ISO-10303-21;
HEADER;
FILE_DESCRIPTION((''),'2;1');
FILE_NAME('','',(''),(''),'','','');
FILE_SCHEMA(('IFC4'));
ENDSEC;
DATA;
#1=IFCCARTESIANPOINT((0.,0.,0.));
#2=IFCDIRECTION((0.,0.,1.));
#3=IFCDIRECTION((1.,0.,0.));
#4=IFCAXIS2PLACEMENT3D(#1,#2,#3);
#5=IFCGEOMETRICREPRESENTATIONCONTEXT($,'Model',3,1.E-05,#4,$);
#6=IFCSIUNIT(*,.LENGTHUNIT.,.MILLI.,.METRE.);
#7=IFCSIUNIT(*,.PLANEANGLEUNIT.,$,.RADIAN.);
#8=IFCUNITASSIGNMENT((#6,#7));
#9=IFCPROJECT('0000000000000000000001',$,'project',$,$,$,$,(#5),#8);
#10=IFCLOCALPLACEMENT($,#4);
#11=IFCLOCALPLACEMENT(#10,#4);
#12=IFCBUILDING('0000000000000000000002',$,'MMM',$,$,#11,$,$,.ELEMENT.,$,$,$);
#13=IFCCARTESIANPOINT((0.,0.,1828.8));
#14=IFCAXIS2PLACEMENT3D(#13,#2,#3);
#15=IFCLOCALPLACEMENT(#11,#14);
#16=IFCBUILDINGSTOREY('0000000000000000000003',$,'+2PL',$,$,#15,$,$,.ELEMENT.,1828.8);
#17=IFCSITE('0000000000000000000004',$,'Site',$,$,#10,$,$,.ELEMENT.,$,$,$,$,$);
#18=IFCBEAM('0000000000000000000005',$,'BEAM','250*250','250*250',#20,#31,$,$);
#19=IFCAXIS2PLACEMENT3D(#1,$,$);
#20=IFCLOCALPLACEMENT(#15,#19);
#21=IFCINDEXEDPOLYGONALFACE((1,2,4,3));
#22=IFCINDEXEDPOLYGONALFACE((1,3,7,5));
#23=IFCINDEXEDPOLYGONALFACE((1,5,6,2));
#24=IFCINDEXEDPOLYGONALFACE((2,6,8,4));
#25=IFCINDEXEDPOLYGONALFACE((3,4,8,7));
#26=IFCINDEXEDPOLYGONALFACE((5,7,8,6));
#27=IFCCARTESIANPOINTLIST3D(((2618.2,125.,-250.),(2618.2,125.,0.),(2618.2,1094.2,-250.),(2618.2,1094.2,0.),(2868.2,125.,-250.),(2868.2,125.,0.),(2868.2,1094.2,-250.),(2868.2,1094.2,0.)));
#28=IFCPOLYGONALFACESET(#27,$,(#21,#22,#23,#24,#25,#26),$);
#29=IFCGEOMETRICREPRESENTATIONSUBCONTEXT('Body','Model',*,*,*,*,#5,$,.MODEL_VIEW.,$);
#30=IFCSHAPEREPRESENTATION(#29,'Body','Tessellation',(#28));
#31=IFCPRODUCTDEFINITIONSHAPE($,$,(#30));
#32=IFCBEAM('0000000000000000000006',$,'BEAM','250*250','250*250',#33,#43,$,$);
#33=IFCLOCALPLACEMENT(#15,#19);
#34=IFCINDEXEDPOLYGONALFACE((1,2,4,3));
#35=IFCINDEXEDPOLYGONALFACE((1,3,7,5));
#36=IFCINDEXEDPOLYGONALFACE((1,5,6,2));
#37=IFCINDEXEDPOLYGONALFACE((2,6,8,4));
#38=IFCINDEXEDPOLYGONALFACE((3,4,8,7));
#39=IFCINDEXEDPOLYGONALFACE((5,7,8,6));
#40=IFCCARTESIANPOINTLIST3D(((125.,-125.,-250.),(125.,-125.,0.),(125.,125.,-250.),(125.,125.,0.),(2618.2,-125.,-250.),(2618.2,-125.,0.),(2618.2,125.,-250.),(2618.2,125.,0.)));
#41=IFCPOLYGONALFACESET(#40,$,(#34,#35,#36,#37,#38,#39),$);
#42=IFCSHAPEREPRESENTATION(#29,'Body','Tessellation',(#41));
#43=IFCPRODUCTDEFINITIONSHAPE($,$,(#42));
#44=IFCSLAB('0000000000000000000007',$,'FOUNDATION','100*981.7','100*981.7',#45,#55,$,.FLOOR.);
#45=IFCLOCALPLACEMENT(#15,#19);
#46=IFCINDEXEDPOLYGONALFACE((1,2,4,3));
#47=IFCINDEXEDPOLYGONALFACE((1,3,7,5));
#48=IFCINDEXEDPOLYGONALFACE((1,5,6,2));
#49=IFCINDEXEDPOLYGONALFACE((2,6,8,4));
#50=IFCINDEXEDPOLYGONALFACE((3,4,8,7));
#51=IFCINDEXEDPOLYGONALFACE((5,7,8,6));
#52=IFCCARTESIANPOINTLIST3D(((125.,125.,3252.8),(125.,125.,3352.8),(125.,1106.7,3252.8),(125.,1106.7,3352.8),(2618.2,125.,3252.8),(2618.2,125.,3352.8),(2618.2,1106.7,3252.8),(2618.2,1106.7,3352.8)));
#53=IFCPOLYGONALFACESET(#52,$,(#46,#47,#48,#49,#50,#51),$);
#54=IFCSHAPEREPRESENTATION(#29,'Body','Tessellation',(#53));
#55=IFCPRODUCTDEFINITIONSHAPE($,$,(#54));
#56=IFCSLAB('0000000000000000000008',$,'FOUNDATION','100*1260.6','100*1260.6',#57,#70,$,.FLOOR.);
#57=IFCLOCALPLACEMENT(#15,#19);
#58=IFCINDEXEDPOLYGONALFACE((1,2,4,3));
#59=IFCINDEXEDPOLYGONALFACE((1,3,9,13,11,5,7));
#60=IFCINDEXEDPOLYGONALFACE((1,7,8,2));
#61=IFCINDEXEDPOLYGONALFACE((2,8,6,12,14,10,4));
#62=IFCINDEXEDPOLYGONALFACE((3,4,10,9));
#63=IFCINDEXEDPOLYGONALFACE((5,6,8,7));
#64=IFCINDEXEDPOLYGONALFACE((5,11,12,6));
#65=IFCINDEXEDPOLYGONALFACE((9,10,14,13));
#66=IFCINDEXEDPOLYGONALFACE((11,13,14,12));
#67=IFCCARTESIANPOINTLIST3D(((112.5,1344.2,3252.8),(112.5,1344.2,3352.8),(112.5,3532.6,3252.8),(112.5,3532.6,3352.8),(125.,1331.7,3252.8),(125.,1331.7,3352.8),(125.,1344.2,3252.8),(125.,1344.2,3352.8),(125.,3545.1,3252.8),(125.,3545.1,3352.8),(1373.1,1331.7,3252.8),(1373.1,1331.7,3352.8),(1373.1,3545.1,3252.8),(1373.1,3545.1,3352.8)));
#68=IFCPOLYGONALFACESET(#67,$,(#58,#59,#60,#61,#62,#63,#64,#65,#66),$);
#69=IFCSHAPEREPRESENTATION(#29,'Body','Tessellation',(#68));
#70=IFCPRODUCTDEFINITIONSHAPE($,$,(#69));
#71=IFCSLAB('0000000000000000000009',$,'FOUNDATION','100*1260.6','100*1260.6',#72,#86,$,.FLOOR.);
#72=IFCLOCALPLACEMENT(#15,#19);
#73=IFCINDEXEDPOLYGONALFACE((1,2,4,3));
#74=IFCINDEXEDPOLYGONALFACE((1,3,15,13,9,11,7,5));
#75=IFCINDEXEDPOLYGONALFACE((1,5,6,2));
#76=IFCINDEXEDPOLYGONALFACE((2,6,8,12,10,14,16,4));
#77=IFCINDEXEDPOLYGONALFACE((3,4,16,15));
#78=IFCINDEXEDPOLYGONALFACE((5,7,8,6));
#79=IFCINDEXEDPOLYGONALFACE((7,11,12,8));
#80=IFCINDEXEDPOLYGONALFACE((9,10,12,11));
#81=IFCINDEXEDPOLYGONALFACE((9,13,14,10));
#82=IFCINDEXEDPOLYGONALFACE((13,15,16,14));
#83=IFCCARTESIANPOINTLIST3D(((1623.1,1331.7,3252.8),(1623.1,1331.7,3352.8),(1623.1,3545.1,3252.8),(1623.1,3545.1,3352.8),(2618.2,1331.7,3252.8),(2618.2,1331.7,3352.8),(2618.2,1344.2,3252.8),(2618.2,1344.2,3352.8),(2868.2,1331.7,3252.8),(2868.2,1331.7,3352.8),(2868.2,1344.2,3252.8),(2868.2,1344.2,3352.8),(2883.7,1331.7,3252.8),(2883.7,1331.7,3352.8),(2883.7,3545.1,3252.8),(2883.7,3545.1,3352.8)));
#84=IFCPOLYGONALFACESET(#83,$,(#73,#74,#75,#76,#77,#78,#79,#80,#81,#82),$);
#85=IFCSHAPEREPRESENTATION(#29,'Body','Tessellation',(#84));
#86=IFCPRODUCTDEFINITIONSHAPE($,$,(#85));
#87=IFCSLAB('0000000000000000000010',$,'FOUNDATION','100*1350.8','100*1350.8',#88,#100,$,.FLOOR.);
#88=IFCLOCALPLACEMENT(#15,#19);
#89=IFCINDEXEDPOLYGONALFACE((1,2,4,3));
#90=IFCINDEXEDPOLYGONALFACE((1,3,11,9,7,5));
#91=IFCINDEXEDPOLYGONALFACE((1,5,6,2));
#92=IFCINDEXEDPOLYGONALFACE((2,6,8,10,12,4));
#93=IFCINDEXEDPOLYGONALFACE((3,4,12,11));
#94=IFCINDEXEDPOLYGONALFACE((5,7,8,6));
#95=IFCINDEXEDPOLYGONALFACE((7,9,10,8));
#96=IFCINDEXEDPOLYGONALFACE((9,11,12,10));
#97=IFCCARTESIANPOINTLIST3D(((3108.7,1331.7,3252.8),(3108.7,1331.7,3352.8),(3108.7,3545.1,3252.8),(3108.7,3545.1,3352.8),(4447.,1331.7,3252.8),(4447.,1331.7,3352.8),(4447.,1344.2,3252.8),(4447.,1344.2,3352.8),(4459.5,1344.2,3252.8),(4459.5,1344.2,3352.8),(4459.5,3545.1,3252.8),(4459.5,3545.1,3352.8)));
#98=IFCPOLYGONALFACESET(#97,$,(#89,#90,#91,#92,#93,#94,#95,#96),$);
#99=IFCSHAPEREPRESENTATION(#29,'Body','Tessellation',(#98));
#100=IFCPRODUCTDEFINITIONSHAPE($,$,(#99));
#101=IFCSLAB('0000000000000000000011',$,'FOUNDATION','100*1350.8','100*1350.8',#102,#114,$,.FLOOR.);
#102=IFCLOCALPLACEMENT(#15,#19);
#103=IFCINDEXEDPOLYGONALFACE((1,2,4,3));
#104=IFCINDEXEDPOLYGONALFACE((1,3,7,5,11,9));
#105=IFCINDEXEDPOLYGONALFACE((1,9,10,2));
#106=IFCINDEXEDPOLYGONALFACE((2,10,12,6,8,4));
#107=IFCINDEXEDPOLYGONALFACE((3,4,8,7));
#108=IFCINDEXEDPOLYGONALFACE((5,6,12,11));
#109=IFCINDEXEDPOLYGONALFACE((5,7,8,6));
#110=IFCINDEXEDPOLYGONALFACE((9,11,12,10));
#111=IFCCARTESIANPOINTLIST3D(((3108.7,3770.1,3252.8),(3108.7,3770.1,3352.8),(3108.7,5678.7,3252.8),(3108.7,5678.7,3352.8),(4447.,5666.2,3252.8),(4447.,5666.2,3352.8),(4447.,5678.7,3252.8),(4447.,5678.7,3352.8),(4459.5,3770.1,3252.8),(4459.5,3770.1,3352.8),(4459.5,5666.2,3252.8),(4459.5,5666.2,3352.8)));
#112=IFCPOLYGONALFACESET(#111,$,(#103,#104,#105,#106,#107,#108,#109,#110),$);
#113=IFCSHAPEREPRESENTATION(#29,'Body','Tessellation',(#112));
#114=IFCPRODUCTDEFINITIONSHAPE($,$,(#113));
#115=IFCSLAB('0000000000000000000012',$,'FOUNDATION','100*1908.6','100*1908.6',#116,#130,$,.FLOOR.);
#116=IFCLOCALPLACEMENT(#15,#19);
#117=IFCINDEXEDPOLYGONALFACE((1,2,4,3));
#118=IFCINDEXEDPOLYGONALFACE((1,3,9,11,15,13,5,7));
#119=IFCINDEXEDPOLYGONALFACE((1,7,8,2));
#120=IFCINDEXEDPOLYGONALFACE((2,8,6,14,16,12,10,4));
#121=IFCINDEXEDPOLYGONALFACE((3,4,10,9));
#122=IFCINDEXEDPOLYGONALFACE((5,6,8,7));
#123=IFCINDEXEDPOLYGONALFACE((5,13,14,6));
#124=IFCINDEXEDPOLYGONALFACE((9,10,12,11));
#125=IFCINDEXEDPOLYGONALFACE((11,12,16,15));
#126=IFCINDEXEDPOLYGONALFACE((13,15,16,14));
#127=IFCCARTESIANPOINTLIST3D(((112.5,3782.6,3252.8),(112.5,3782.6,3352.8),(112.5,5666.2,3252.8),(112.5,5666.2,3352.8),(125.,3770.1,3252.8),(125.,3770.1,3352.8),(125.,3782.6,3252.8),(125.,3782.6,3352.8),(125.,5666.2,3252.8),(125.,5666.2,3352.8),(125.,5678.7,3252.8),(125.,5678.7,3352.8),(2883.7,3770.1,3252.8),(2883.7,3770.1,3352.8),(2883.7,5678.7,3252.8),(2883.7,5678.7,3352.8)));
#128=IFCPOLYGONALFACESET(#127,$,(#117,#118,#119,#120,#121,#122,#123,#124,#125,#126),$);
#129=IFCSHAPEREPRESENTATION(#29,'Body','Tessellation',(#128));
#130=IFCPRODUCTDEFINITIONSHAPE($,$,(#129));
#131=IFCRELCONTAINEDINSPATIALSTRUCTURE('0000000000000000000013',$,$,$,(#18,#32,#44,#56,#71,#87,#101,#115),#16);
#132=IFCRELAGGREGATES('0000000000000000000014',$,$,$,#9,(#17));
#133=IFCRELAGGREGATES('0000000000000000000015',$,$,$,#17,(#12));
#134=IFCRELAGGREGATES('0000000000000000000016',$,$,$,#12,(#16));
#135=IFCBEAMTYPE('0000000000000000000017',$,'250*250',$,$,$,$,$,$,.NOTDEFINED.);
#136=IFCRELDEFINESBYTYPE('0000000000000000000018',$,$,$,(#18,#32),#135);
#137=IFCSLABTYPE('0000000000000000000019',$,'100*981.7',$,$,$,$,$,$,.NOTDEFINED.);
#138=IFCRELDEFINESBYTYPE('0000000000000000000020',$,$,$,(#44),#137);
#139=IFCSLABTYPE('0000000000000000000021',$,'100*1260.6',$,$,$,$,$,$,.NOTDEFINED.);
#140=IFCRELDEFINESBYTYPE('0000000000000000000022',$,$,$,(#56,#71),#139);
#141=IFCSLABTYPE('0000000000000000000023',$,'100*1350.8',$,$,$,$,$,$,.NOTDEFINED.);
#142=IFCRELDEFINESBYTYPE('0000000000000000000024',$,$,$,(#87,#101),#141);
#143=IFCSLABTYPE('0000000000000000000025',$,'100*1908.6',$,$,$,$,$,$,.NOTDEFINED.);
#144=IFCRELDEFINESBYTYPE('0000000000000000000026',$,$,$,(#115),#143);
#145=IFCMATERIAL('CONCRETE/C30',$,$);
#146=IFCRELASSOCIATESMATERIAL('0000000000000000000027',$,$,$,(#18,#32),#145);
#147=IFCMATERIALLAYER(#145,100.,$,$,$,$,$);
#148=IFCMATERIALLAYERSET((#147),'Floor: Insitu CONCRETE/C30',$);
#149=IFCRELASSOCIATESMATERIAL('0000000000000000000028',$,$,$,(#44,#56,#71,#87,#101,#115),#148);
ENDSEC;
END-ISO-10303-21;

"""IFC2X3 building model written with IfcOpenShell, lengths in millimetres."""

from ifc_helpers import new_model, si_unit, frame, origin_with_axes, origin_2d_with_axis, place, context, subcontext, project, spatial, polyline, rectangle, outline, extrude, material, layer, layer_set, layer_usage, type_object, element, save


model = new_model("IFC2X3")

# Units and contexts
model_context = context("Model", 3, precision=1e-05, world=origin_with_axes())
body_context = subcontext(model_context, "Body", "Model", "MODEL_VIEW")
ifc_project = project(units=[si_unit("LENGTHUNIT", "METRE", prefix="MILLI"), si_unit("PLANEANGLEUNIT", "RADIAN")], contexts=[model_context])

# Site, building, storey
site_placement = place(None, origin_with_axes())
site = spatial("IfcSite", under=ifc_project, at=site_placement, Name="Site", CompositionType="ELEMENT")
building_placement = place(site_placement, origin_with_axes())
building = spatial("IfcBuilding", under=site, at=building_placement, Name="MMM", CompositionType="ELEMENT")
storey_placement = place(building_placement, frame((0.0, 0.0, 1828.8), z_axis=(0.0, 0.0, 1.0), x_axis=(1.0, 0.0, 0.0)))
storey = spatial("IfcBuildingStorey", under=building, at=storey_placement, Name="+2PL", CompositionType="ELEMENT", Elevation=1828.8)

# Shared definitions
ifc_material = material(Name="CONCRETE/C30")

# Beams
beam_type_1 = type_object("IfcBeamType", Name="250*250", PredefinedType="NOTDEFINED")
for number, where, z_axis, x_axis, name in (
    (1, (2743.2, 125.0, -125.0), (0.0, 0.0, 1.0), (0.0, 1.0, 0.0), "BEAM"),
):
    element("IfcBeam", number, at=place(storey_placement, frame(where, z_axis=z_axis, x_axis=x_axis)), inside=storey, type_object=beam_type_1, material=ifc_material, Name=name, Description="250*250", ObjectType="250*250", context=body_context, shape_type="SweptSolid", body=[
        extrude(rectangle(XDim=250.0, YDim=250.0, at=origin_2d_with_axis()), frame((969.2, 0.0, 0.0), z_axis=(-1.0, 0.0, 0.0), x_axis=(0.0, -1.0, 0.0)), (0.0, 0.0, 1.0), 969.2),
    ])
beam_1_placement = place(storey_placement, frame((125.0, 0.0, -125.0), z_axis=(0.0, 0.0, 1.0), x_axis=(1.0, 0.0, 0.0)))
element("IfcBeam", 2, at=beam_1_placement, inside=storey, type_object=beam_type_1, material=ifc_material, Name="BEAM", Description="250*250", ObjectType="250*250", context=body_context, shape_type="SweptSolid", body=[
    extrude(rectangle(XDim=250.0, YDim=250.0, at=origin_2d_with_axis()), frame((2493.2, 0.0, 0.0), z_axis=(-1.0, 0.0, 0.0), x_axis=(0.0, -1.0, 0.0)), (0.0, 0.0, 1.0), 2493.2),
])

# Slabs
ifc_layer = layer(ifc_material, 100.0)
ifc_layer_set = layer_set([ifc_layer], Name="Floor: Insitu CONCRETE/C30")
ifc_layer_usage_1 = layer_usage(ifc_layer_set, "AXIS3", "POSITIVE", -50.0)
slab_type_1 = type_object("IfcSlabType", Name="100*981.7", PredefinedType="NOTDEFINED")
slab_1_placement = place(storey_placement, frame((125.0, 125.0, 3302.8), z_axis=(0.0, 0.0, 1.0), x_axis=(1.0, 0.0, 0.0)))
element("IfcSlab", 3, at=slab_1_placement, inside=storey, type_object=slab_type_1, material=ifc_layer_usage_1, Name="FOUNDATION", Description="100*981.7", ObjectType="100*981.7", PredefinedType="FLOOR", context=body_context, shape_type="SweptSolid", body=[
    extrude(outline(polyline([(0.0, 0.0), (2493.2, 0.0), (2493.2, 981.7), (0.0, 981.7), (0.0, 0.0)])), frame((0.0, 0.0, -50.0), z_axis=(0.0, 0.0, 1.0), x_axis=(1.0, 0.0, 0.0)), (0.0, 0.0, 1.0), 100.0),
])
ifc_layer_usage_2 = layer_usage(ifc_layer_set, "AXIS3", "POSITIVE", -50.0)
slab_type_2 = type_object("IfcSlabType", Name="100*1260.6", PredefinedType="NOTDEFINED")
slab_2_placement = place(storey_placement, frame((125.0, 1331.7, 3302.8), z_axis=(0.0, 0.0, 1.0), x_axis=(1.0, 0.0, 0.0)))
element("IfcSlab", 4, at=slab_2_placement, inside=storey, type_object=slab_type_2, material=ifc_layer_usage_2, Name="FOUNDATION", Description="100*1260.6", ObjectType="100*1260.6", PredefinedType="FLOOR", context=body_context, shape_type="SweptSolid", body=[
    extrude(outline(polyline([(0.0, 0.0), (1248.1, 0.0), (1248.1, 2213.4), (0.0, 2213.4), (-12.5, 2200.9), (-12.5, 12.5), (0.0, 12.5), (0.0, 0.0)])), frame((0.0, 0.0, -50.0), z_axis=(0.0, 0.0, 1.0), x_axis=(1.0, 0.0, 0.0)), (0.0, 0.0, 1.0), 100.0),
])
ifc_layer_usage_3 = layer_usage(ifc_layer_set, "AXIS3", "POSITIVE", -50.0)
slab_3_placement = place(storey_placement, frame((2883.7, 3545.1, 3302.8), z_axis=(0.0, 0.0, 1.0), x_axis=(-1.0, 0.0, 0.0)))
element("IfcSlab", 5, at=slab_3_placement, inside=storey, type_object=slab_type_2, material=ifc_layer_usage_3, Name="FOUNDATION", Description="100*1260.6", ObjectType="100*1260.6", PredefinedType="FLOOR", context=body_context, shape_type="SweptSolid", body=[
    extrude(outline(polyline([(0.0, 0.0), (1260.6, 0.0), (1260.6, 2213.4), (265.5, 2213.4), (265.5, 2200.9), (15.5, 2200.9), (15.5, 2213.4), (0.0, 2213.4), (0.0, 0.0)])), frame((0.0, 0.0, -50.0), z_axis=(0.0, 0.0, 1.0), x_axis=(1.0, 0.0, 0.0)), (0.0, 0.0, 1.0), 100.0),
])
ifc_layer_usage_4 = layer_usage(ifc_layer_set, "AXIS3", "POSITIVE", -50.0)
slab_type_3 = type_object("IfcSlabType", Name="100*1350.8", PredefinedType="NOTDEFINED")
slab_4_placement = place(storey_placement, frame((4459.5, 1344.2, 3302.8), z_axis=(0.0, 0.0, 1.0), x_axis=(0.0, 1.0, 0.0)))
element("IfcSlab", 6, at=slab_4_placement, inside=storey, type_object=slab_type_3, material=ifc_layer_usage_4, Name="FOUNDATION", Description="100*1350.8", ObjectType="100*1350.8", PredefinedType="FLOOR", context=body_context, shape_type="SweptSolid", body=[
    extrude(outline(polyline([(0.0, 0.0), (2200.9, 0.0), (2200.9, 1350.8), (-12.5, 1350.8), (-12.5, 12.5), (0.0, 12.5), (0.0, 0.0)])), frame((0.0, 0.0, -50.0), z_axis=(0.0, 0.0, 1.0), x_axis=(1.0, 0.0, 0.0)), (0.0, 0.0, 1.0), 100.0),
])
ifc_layer_usage_5 = layer_usage(ifc_layer_set, "AXIS3", "POSITIVE", -50.0)
slab_5_placement = place(storey_placement, frame((3108.7, 3770.1, 3302.8), z_axis=(0.0, 0.0, 1.0), x_axis=(1.0, 0.0, 0.0)))
element("IfcSlab", 7, at=slab_5_placement, inside=storey, type_object=slab_type_3, material=ifc_layer_usage_5, Name="FOUNDATION", Description="100*1350.8", ObjectType="100*1350.8", PredefinedType="FLOOR", context=body_context, shape_type="SweptSolid", body=[
    extrude(outline(polyline([(0.0, 0.0), (1350.8, 0.0), (1350.8, 1896.1), (1338.3, 1896.1), (1338.3, 1908.6), (0.0, 1908.6), (0.0, 0.0)])), frame((0.0, 0.0, -50.0), z_axis=(0.0, 0.0, 1.0), x_axis=(1.0, 0.0, 0.0)), (0.0, 0.0, 1.0), 100.0),
])
ifc_layer_usage_6 = layer_usage(ifc_layer_set, "AXIS3", "POSITIVE", -50.0)
slab_type_4 = type_object("IfcSlabType", Name="100*1908.6", PredefinedType="NOTDEFINED")
slab_6_placement = place(storey_placement, frame((112.5, 3782.6, 3302.8), z_axis=(0.0, 0.0, 1.0), x_axis=(1.0, 0.0, 0.0)))
element("IfcSlab", 8, at=slab_6_placement, inside=storey, type_object=slab_type_4, material=ifc_layer_usage_6, Name="FOUNDATION", Description="100*1908.6", ObjectType="100*1908.6", PredefinedType="FLOOR", context=body_context, shape_type="SweptSolid", body=[
    extrude(outline(polyline([(0.0, 0.0), (12.5, 0.0), (12.5, -12.5), (2771.2, -12.5), (2771.2, 1896.1), (12.5, 1896.1), (12.5, 1883.6), (0.0, 1883.6), (0.0, 0.0)])), frame((0.0, 0.0, -50.0), z_axis=(0.0, 0.0, 1.0), x_axis=(1.0, 0.0, 0.0)), (0.0, 0.0, 1.0), 100.0),
])

save(model, "model.ifc")
